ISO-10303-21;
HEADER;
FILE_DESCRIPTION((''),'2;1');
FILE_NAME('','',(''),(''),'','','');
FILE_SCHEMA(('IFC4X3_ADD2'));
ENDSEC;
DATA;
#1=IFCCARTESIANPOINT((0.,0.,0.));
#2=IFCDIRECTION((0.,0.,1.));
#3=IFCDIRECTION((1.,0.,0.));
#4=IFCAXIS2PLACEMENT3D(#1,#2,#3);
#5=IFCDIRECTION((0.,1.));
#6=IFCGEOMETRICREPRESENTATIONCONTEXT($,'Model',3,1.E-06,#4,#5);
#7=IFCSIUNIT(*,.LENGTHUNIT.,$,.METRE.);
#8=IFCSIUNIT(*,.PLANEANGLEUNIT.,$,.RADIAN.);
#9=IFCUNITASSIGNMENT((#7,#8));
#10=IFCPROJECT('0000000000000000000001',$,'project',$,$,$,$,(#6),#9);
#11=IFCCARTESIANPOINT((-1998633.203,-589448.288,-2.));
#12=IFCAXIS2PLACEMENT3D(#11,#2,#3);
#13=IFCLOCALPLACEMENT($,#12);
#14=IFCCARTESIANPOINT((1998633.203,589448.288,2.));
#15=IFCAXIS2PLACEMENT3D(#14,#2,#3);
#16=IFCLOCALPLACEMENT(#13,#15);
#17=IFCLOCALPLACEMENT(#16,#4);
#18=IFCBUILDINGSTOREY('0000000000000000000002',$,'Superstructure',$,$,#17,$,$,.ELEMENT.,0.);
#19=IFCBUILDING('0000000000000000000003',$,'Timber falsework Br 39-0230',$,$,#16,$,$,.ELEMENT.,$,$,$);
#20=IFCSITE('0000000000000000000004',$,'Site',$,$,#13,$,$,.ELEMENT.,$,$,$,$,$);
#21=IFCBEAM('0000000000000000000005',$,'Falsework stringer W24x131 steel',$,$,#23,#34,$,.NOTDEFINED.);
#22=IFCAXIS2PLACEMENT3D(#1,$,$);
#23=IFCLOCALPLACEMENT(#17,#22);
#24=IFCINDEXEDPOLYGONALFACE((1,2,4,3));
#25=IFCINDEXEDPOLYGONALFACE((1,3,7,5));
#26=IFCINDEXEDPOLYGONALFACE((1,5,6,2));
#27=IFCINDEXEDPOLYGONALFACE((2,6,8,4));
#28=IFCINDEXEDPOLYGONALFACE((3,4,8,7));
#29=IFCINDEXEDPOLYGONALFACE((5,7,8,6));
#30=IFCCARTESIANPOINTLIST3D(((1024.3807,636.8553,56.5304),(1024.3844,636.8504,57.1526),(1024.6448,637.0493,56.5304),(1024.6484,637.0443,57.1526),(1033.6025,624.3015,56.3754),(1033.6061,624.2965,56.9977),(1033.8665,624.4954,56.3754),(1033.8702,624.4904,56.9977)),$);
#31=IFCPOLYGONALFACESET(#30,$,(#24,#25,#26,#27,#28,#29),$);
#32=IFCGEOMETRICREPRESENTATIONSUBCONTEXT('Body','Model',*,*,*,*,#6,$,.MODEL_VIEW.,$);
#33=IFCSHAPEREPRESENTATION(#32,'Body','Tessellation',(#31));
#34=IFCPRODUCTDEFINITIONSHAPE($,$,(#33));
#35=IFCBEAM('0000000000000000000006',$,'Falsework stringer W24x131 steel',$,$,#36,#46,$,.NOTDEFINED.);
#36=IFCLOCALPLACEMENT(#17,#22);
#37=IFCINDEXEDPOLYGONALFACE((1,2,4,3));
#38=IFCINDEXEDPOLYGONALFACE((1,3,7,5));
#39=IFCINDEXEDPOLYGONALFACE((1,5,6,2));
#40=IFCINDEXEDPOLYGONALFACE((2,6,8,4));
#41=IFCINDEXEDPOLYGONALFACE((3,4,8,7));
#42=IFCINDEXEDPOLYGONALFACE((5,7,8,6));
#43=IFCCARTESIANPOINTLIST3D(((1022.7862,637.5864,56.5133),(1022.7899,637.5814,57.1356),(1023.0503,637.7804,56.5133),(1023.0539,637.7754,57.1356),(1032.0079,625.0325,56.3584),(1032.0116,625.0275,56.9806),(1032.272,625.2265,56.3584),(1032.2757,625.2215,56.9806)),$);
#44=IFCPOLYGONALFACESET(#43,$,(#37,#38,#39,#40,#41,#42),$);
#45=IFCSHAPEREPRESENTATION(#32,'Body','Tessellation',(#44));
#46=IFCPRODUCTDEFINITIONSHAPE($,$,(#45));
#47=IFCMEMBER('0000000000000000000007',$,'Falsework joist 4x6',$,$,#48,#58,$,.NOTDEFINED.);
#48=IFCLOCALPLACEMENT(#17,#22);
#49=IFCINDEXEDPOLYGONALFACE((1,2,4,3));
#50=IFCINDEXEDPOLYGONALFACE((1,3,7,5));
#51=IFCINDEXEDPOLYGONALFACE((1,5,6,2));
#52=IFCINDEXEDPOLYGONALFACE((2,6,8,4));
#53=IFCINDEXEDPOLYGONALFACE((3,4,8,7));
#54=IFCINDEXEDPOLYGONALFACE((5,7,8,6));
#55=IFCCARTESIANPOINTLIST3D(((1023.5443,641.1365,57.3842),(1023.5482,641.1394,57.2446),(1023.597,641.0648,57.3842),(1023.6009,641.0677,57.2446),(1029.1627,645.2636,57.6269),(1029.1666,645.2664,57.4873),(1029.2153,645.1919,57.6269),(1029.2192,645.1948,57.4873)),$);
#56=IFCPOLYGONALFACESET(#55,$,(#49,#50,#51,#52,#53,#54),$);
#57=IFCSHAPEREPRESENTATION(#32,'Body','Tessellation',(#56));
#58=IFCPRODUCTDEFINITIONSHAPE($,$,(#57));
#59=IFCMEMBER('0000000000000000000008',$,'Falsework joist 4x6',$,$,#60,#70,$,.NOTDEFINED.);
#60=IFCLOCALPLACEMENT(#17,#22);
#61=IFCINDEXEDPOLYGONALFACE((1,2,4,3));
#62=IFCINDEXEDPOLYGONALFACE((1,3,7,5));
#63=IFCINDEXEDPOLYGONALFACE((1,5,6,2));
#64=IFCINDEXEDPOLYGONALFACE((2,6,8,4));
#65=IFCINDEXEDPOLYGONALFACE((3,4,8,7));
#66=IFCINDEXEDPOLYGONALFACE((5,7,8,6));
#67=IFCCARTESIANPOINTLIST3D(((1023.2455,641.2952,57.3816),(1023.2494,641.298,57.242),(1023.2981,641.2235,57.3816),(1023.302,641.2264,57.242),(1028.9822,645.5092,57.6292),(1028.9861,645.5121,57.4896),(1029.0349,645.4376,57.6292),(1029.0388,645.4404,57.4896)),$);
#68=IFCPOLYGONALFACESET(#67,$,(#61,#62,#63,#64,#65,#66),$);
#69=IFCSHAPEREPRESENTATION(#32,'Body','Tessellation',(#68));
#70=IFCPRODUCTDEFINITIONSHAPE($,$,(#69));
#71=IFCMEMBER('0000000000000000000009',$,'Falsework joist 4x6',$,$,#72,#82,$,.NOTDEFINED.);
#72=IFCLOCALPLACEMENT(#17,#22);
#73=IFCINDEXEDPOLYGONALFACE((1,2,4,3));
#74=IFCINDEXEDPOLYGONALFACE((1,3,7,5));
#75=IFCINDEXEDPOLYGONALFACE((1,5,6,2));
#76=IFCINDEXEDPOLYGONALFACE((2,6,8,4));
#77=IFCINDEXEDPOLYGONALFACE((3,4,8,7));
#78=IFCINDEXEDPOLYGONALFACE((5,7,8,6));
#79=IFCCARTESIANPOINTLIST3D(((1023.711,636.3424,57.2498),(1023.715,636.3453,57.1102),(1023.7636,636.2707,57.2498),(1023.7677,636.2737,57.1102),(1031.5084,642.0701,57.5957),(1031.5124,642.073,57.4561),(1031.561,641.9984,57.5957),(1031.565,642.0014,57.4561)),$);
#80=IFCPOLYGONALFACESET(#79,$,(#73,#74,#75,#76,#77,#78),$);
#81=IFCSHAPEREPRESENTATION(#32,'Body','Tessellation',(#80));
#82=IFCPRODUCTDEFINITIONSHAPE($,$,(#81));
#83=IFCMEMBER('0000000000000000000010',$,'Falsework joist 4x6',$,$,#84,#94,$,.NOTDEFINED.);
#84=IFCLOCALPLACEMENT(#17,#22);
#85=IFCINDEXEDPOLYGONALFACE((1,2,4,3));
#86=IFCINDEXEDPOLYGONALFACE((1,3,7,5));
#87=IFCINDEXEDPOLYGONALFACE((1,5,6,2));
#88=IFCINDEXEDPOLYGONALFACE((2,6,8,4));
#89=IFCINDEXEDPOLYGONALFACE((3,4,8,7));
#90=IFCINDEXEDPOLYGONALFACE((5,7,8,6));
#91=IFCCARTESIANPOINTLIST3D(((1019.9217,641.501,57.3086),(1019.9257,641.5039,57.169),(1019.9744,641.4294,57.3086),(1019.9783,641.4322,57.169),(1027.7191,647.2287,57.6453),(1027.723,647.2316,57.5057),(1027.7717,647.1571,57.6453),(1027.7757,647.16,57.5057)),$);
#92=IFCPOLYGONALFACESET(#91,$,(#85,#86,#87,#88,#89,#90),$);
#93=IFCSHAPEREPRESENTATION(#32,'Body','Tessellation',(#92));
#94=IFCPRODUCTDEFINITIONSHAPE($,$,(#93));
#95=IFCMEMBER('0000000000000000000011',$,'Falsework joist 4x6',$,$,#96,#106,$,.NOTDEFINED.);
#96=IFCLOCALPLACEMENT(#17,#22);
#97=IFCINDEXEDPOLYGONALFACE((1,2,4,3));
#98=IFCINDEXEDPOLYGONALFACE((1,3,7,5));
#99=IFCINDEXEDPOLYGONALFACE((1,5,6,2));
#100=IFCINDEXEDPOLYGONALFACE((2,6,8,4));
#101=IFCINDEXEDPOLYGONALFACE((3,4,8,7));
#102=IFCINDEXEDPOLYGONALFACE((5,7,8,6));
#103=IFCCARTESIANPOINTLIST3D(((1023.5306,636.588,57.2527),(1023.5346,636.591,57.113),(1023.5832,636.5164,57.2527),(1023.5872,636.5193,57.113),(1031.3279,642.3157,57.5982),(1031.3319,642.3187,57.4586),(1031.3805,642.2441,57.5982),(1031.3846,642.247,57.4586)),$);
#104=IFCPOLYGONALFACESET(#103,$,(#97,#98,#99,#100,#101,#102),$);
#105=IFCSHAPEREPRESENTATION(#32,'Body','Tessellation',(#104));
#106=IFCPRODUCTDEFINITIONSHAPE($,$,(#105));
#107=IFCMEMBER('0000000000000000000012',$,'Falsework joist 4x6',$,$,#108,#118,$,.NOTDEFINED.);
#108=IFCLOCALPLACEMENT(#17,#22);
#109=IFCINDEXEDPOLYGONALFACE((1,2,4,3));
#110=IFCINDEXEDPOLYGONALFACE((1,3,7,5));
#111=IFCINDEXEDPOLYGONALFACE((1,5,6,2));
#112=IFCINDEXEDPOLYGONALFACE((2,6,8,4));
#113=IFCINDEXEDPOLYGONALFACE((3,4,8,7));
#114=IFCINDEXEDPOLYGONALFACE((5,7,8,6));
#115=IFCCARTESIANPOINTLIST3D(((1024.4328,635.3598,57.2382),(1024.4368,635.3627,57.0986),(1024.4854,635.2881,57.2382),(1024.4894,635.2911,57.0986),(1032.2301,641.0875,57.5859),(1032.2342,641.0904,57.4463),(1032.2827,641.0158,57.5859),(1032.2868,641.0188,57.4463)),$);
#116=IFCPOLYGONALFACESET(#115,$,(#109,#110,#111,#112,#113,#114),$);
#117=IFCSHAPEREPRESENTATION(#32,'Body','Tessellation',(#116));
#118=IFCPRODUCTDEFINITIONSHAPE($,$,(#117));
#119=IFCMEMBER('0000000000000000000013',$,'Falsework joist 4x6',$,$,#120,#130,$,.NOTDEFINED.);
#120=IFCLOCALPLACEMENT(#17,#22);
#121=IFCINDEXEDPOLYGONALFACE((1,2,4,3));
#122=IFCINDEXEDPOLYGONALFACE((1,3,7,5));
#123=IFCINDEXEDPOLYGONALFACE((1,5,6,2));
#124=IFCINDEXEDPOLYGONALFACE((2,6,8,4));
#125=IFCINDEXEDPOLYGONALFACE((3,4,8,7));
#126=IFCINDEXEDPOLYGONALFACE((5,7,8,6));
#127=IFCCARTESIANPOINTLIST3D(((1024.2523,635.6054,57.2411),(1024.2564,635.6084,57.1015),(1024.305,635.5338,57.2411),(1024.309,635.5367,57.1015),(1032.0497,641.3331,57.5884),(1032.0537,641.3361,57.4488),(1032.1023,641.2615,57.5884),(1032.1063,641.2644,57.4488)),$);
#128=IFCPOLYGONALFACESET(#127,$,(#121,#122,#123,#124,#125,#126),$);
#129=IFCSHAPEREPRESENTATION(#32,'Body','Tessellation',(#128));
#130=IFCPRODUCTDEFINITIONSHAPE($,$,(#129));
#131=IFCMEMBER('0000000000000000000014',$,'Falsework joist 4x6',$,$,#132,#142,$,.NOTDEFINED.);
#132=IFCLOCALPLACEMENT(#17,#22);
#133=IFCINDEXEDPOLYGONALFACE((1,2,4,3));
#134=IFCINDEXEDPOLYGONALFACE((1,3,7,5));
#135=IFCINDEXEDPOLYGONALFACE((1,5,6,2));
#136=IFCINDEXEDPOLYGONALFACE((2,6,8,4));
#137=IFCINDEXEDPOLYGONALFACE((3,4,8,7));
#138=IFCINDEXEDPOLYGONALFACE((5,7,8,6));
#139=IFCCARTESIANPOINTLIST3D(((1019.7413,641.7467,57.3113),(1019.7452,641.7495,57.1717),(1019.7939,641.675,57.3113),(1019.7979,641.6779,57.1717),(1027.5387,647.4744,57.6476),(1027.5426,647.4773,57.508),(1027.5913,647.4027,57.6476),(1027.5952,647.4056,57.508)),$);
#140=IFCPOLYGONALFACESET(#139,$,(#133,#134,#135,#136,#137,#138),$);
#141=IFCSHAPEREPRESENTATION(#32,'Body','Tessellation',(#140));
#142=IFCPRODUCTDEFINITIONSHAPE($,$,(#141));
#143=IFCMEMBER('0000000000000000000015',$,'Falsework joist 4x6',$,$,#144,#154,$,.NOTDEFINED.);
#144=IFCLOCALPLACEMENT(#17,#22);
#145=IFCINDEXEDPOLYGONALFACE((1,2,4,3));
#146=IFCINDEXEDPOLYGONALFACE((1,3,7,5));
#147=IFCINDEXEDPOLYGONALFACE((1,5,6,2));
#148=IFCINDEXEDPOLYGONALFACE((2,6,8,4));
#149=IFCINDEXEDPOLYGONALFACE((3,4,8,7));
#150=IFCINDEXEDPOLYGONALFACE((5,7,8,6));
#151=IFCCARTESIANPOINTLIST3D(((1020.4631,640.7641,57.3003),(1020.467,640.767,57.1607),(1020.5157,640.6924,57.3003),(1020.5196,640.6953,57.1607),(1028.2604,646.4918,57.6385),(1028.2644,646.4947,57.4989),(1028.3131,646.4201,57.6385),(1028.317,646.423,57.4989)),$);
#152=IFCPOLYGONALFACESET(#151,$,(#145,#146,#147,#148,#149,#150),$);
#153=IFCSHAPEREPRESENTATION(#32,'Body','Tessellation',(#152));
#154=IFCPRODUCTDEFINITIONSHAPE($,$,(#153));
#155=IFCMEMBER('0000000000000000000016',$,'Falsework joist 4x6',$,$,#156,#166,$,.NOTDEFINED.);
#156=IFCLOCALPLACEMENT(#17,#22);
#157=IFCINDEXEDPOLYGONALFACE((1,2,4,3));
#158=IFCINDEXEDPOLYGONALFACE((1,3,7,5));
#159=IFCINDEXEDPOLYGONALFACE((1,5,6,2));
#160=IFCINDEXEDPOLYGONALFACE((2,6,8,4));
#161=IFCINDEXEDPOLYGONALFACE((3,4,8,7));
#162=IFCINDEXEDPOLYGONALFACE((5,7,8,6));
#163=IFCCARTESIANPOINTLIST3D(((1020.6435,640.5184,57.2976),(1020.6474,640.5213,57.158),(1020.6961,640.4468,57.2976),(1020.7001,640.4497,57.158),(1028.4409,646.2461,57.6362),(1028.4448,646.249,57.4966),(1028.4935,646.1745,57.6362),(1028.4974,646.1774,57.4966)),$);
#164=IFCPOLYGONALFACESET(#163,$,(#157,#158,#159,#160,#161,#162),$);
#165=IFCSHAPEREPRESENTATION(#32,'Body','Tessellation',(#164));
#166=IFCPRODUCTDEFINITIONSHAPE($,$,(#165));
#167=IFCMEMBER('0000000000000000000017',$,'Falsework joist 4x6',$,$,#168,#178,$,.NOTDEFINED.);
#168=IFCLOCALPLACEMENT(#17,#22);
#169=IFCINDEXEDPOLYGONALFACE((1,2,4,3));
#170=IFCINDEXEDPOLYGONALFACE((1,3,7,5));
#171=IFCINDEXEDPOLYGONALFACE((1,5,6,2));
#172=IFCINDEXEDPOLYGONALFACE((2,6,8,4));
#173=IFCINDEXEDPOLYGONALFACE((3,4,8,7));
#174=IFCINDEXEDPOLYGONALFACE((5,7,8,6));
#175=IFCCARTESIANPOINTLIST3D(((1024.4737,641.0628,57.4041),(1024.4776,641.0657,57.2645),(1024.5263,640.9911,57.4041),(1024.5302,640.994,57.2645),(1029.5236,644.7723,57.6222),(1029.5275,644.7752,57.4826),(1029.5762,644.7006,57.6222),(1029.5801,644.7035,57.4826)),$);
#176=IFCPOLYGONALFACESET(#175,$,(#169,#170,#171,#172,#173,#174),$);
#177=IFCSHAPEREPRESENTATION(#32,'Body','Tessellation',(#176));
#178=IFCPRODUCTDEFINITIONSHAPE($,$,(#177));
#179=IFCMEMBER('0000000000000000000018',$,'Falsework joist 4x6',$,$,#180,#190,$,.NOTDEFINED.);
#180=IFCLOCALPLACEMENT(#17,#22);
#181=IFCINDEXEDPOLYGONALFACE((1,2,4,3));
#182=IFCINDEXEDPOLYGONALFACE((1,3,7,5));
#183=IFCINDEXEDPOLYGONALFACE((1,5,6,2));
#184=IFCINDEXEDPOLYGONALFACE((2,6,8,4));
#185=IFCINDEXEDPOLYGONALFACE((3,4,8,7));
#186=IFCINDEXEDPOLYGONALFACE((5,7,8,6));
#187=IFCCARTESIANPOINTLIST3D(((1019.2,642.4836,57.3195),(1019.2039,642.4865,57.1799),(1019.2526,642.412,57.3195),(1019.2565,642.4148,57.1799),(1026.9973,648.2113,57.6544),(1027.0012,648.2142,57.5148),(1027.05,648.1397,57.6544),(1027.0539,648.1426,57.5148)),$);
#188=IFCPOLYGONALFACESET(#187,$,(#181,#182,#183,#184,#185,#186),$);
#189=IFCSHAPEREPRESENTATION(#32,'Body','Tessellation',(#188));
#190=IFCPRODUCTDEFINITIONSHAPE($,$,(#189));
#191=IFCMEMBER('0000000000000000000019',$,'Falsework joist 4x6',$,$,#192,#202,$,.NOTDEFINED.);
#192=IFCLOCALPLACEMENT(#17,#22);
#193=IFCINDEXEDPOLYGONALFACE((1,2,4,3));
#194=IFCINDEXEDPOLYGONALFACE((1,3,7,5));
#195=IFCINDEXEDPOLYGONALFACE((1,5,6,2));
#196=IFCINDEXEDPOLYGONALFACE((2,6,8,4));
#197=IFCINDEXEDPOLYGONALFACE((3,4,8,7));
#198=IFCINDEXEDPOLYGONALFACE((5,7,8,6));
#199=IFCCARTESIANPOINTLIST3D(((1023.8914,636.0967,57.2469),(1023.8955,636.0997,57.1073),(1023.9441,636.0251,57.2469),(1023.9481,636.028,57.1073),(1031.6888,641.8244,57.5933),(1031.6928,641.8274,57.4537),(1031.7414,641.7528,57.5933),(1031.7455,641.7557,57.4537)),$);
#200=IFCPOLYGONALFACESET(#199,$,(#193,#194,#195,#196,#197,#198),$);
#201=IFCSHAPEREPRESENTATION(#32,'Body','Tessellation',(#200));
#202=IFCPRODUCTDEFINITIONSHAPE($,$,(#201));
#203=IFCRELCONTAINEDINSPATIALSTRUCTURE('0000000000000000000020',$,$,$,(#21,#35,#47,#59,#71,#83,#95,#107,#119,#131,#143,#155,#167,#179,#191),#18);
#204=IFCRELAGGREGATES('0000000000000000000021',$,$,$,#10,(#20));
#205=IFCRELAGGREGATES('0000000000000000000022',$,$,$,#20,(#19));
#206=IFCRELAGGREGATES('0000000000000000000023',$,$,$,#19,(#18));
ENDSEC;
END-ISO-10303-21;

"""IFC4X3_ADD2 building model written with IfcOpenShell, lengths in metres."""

from ifc_helpers import new_model, si_unit, direction, frame, frame_2d, origin, origin_with_axes, place, context, subcontext, project, spatial, rectangle, extrude, element, save


model = new_model("IFC4X3_ADD2")

# Units and contexts
model_context = context("Model", 3, precision=1e-06, world=origin_with_axes(), true_north=direction((0.0, 1.0)))
body_context = subcontext(model_context, "Body", "Model", "MODEL_VIEW")
ifc_project = project(units=[si_unit("LENGTHUNIT", "METRE"), si_unit("PLANEANGLEUNIT", "RADIAN")], contexts=[model_context])

# Site, building, storey
site_placement = place(None, frame((-1998633.203, -589448.288, -2.0), z_axis=(0.0, 0.0, 1.0), x_axis=(1.0, 0.0, 0.0)))
site = spatial("IfcSite", under=ifc_project, at=site_placement, Name="Site", CompositionType="ELEMENT")
building_placement = place(site_placement, frame((1998633.203, 589448.288, 2.0), z_axis=(0.0, 0.0, 1.0), x_axis=(1.0, 0.0, 0.0)))
building = spatial("IfcBuilding", under=site, at=building_placement, Name="Timber falsework Br 39-0230", CompositionType="ELEMENT")
storey_placement = place(building_placement, origin_with_axes())
storey = spatial("IfcBuildingStorey", under=building, at=storey_placement, Name="Superstructure", CompositionType="ELEMENT", Elevation=0.0)

# Beams
beam_1_placement = place(storey_placement, frame((1024.5127, 636.9523, 56.5304), z_axis=(0.591984, -0.805888, -0.009947), x_axis=(0.805928, 0.592013, 0.0)))
element("IfcBeam", 1, at=beam_1_placement, inside=storey, Name="Falsework stringer W24x131 steel", PredefinedType="NOTDEFINED", context=body_context, shape_type="SweptSolid", body=[
    extrude(rectangle(XDim=0.3277, YDim=0.6223, at=frame_2d((0.0, 0.3111))), origin(), (0.0, 0.0, 1.0), 15.5777),
])
beam_2_placement = place(storey_placement, frame((1022.9182, 637.6834, 56.5133), z_axis=(0.591984, -0.805888, -0.009947), x_axis=(0.805928, 0.592013, 0.0)))
element("IfcBeam", 2, at=beam_2_placement, inside=storey, Name="Falsework stringer W24x131 steel", PredefinedType="NOTDEFINED", context=body_context, shape_type="SweptSolid", body=[
    extrude(rectangle(XDim=0.3277, YDim=0.6223, at=frame_2d((0.0, 0.3111))), origin(), (0.0, 0.0, 1.0), 15.5777),
])

# Members
member_1_placement = place(storey_placement, frame((1023.5746, 641.1035, 57.2446), z_axis=(0.805441, 0.591655, 0.034785), x_axis=(-0.592013, 0.805928, 0.0)))
element("IfcMember", 3, at=member_1_placement, inside=storey, Name="Falsework joist 4x6", PredefinedType="NOTDEFINED", context=body_context, shape_type="SweptSolid", body=[
    extrude(rectangle(XDim=0.0889, YDim=0.1397, at=frame_2d((0.0, 0.0698))), origin(), (0.0, 0.0, 1.0), 6.9755),
])
member_2_placement = place(storey_placement, frame((1023.2757, 641.2622, 57.242), z_axis=(0.805441, 0.591655, 0.034758), x_axis=(-0.592013, 0.805928, 0.0)))
element("IfcMember", 4, at=member_2_placement, inside=storey, Name="Falsework joist 4x6", PredefinedType="NOTDEFINED", context=body_context, shape_type="SweptSolid", body=[
    extrude(rectangle(XDim=0.0889, YDim=0.1397, at=frame_2d((0.0, 0.0698))), origin(), (0.0, 0.0, 1.0), 7.1225),
])
member_3_placement = place(storey_placement, frame((1023.7413, 636.3095, 57.1102), z_axis=(0.805414, 0.591635, 0.035736), x_axis=(-0.592013, 0.805928, 0.0)))
element("IfcMember", 5, at=member_3_placement, inside=storey, Name="Falsework joist 4x6", PredefinedType="NOTDEFINED", context=body_context, shape_type="SweptSolid", body=[
    extrude(rectangle(XDim=0.0889, YDim=0.1397, at=frame_2d((0.0, 0.0698))), origin(), (0.0, 0.0, 1.0), 9.6812),
])
member_4_placement = place(storey_placement, frame((1019.952, 641.4681, 57.169), z_axis=(0.805441, 0.591655, 0.034784), x_axis=(-0.592013, 0.805928, 0.0)))
element("IfcMember", 6, at=member_4_placement, inside=storey, Name="Falsework joist 4x6", PredefinedType="NOTDEFINED", context=body_context, shape_type="SweptSolid", body=[
    extrude(rectangle(XDim=0.0889, YDim=0.1397, at=frame_2d((0.0, 0.0698))), origin(), (0.0, 0.0, 1.0), 9.6809),
])
member_5_placement = place(storey_placement, frame((1023.5609, 636.5551, 57.113), z_axis=(0.805415, 0.591636, 0.035691), x_axis=(-0.592013, 0.805928, 0.0)))
element("IfcMember", 7, at=member_5_placement, inside=storey, Name="Falsework joist 4x6", PredefinedType="NOTDEFINED", context=body_context, shape_type="SweptSolid", body=[
    extrude(rectangle(XDim=0.0889, YDim=0.1397, at=frame_2d((0.0, 0.0698))), origin(), (0.0, 0.0, 1.0), 9.6812),
])
member_6_placement = place(storey_placement, frame((1024.4631, 635.3269, 57.0986), z_axis=(0.805408, 0.591631, 0.035913), x_axis=(-0.592013, 0.805928, 0.0)))
element("IfcMember", 8, at=member_6_placement, inside=storey, Name="Falsework joist 4x6", PredefinedType="NOTDEFINED", context=body_context, shape_type="SweptSolid", body=[
    extrude(rectangle(XDim=0.0889, YDim=0.1397, at=frame_2d((0.0, 0.0698))), origin(), (0.0, 0.0, 1.0), 9.6812),
])
member_7_placement = place(storey_placement, frame((1024.2827, 635.5725, 57.1015), z_axis=(0.80541, 0.591632, 0.035869), x_axis=(-0.592013, 0.805928, 0.0)))
element("IfcMember", 9, at=member_7_placement, inside=storey, Name="Falsework joist 4x6", PredefinedType="NOTDEFINED", context=body_context, shape_type="SweptSolid", body=[
    extrude(rectangle(XDim=0.0889, YDim=0.1397, at=frame_2d((0.0, 0.0698))), origin(), (0.0, 0.0, 1.0), 9.6812),
])
member_8_placement = place(storey_placement, frame((1019.7715, 641.7137, 57.1717), z_axis=(0.805442, 0.591656, 0.034736), x_axis=(-0.592013, 0.805928, 0.0)))
element("IfcMember", 10, at=member_8_placement, inside=storey, Name="Falsework joist 4x6", PredefinedType="NOTDEFINED", context=body_context, shape_type="SweptSolid", body=[
    extrude(rectangle(XDim=0.0889, YDim=0.1397, at=frame_2d((0.0, 0.0698))), origin(), (0.0, 0.0, 1.0), 9.6808),
])
member_9_placement = place(storey_placement, frame((1020.4933, 640.7311, 57.1607), z_axis=(0.805437, 0.591652, 0.034928), x_axis=(-0.592013, 0.805928, 0.0)))
element("IfcMember", 11, at=member_9_placement, inside=storey, Name="Falsework joist 4x6", PredefinedType="NOTDEFINED", context=body_context, shape_type="SweptSolid", body=[
    extrude(rectangle(XDim=0.0889, YDim=0.1397, at=frame_2d((0.0, 0.0698))), origin(), (0.0, 0.0, 1.0), 9.6809),
])
member_10_placement = place(storey_placement, frame((1020.6738, 640.4855, 57.158), z_axis=(0.805435, 0.591651, 0.034976), x_axis=(-0.592013, 0.805928, 0.0)))
element("IfcMember", 12, at=member_10_placement, inside=storey, Name="Falsework joist 4x6", PredefinedType="NOTDEFINED", context=body_context, shape_type="SweptSolid", body=[
    extrude(rectangle(XDim=0.0889, YDim=0.1397, at=frame_2d((0.0, 0.0698))), origin(), (0.0, 0.0, 1.0), 9.6809),
])
member_11_placement = place(storey_placement, frame((1024.5039, 641.0298, 57.2645), z_axis=(0.805441, 0.591655, 0.034781), x_axis=(-0.592013, 0.805928, 0.0)))
element("IfcMember", 13, at=member_11_placement, inside=storey, Name="Falsework joist 4x6", PredefinedType="NOTDEFINED", context=body_context, shape_type="SweptSolid", body=[
    extrude(rectangle(XDim=0.0889, YDim=0.1397, at=frame_2d((0.0, 0.0698))), origin(), (0.0, 0.0, 1.0), 6.2697),
])
member_12_placement = place(storey_placement, frame((1019.2302, 642.4507, 57.1799), z_axis=(0.805446, 0.591659, 0.034592), x_axis=(-0.592013, 0.805928, 0.0)))
element("IfcMember", 14, at=member_12_placement, inside=storey, Name="Falsework joist 4x6", PredefinedType="NOTDEFINED", context=body_context, shape_type="SweptSolid", body=[
    extrude(rectangle(XDim=0.0889, YDim=0.1397, at=frame_2d((0.0, 0.0698))), origin(), (0.0, 0.0, 1.0), 9.6808),
])
member_13_placement = place(storey_placement, frame((1023.9218, 636.0638, 57.1073), z_axis=(0.805412, 0.591634, 0.03578), x_axis=(-0.592013, 0.805928, 0.0)))
element("IfcMember", 15, at=member_13_placement, inside=storey, Name="Falsework joist 4x6", PredefinedType="NOTDEFINED", context=body_context, shape_type="SweptSolid", body=[
    extrude(rectangle(XDim=0.0889, YDim=0.1397, at=frame_2d((0.0, 0.0698))), origin(), (0.0, 0.0, 1.0), 9.6812),
])

save(model, "model.ifc")
